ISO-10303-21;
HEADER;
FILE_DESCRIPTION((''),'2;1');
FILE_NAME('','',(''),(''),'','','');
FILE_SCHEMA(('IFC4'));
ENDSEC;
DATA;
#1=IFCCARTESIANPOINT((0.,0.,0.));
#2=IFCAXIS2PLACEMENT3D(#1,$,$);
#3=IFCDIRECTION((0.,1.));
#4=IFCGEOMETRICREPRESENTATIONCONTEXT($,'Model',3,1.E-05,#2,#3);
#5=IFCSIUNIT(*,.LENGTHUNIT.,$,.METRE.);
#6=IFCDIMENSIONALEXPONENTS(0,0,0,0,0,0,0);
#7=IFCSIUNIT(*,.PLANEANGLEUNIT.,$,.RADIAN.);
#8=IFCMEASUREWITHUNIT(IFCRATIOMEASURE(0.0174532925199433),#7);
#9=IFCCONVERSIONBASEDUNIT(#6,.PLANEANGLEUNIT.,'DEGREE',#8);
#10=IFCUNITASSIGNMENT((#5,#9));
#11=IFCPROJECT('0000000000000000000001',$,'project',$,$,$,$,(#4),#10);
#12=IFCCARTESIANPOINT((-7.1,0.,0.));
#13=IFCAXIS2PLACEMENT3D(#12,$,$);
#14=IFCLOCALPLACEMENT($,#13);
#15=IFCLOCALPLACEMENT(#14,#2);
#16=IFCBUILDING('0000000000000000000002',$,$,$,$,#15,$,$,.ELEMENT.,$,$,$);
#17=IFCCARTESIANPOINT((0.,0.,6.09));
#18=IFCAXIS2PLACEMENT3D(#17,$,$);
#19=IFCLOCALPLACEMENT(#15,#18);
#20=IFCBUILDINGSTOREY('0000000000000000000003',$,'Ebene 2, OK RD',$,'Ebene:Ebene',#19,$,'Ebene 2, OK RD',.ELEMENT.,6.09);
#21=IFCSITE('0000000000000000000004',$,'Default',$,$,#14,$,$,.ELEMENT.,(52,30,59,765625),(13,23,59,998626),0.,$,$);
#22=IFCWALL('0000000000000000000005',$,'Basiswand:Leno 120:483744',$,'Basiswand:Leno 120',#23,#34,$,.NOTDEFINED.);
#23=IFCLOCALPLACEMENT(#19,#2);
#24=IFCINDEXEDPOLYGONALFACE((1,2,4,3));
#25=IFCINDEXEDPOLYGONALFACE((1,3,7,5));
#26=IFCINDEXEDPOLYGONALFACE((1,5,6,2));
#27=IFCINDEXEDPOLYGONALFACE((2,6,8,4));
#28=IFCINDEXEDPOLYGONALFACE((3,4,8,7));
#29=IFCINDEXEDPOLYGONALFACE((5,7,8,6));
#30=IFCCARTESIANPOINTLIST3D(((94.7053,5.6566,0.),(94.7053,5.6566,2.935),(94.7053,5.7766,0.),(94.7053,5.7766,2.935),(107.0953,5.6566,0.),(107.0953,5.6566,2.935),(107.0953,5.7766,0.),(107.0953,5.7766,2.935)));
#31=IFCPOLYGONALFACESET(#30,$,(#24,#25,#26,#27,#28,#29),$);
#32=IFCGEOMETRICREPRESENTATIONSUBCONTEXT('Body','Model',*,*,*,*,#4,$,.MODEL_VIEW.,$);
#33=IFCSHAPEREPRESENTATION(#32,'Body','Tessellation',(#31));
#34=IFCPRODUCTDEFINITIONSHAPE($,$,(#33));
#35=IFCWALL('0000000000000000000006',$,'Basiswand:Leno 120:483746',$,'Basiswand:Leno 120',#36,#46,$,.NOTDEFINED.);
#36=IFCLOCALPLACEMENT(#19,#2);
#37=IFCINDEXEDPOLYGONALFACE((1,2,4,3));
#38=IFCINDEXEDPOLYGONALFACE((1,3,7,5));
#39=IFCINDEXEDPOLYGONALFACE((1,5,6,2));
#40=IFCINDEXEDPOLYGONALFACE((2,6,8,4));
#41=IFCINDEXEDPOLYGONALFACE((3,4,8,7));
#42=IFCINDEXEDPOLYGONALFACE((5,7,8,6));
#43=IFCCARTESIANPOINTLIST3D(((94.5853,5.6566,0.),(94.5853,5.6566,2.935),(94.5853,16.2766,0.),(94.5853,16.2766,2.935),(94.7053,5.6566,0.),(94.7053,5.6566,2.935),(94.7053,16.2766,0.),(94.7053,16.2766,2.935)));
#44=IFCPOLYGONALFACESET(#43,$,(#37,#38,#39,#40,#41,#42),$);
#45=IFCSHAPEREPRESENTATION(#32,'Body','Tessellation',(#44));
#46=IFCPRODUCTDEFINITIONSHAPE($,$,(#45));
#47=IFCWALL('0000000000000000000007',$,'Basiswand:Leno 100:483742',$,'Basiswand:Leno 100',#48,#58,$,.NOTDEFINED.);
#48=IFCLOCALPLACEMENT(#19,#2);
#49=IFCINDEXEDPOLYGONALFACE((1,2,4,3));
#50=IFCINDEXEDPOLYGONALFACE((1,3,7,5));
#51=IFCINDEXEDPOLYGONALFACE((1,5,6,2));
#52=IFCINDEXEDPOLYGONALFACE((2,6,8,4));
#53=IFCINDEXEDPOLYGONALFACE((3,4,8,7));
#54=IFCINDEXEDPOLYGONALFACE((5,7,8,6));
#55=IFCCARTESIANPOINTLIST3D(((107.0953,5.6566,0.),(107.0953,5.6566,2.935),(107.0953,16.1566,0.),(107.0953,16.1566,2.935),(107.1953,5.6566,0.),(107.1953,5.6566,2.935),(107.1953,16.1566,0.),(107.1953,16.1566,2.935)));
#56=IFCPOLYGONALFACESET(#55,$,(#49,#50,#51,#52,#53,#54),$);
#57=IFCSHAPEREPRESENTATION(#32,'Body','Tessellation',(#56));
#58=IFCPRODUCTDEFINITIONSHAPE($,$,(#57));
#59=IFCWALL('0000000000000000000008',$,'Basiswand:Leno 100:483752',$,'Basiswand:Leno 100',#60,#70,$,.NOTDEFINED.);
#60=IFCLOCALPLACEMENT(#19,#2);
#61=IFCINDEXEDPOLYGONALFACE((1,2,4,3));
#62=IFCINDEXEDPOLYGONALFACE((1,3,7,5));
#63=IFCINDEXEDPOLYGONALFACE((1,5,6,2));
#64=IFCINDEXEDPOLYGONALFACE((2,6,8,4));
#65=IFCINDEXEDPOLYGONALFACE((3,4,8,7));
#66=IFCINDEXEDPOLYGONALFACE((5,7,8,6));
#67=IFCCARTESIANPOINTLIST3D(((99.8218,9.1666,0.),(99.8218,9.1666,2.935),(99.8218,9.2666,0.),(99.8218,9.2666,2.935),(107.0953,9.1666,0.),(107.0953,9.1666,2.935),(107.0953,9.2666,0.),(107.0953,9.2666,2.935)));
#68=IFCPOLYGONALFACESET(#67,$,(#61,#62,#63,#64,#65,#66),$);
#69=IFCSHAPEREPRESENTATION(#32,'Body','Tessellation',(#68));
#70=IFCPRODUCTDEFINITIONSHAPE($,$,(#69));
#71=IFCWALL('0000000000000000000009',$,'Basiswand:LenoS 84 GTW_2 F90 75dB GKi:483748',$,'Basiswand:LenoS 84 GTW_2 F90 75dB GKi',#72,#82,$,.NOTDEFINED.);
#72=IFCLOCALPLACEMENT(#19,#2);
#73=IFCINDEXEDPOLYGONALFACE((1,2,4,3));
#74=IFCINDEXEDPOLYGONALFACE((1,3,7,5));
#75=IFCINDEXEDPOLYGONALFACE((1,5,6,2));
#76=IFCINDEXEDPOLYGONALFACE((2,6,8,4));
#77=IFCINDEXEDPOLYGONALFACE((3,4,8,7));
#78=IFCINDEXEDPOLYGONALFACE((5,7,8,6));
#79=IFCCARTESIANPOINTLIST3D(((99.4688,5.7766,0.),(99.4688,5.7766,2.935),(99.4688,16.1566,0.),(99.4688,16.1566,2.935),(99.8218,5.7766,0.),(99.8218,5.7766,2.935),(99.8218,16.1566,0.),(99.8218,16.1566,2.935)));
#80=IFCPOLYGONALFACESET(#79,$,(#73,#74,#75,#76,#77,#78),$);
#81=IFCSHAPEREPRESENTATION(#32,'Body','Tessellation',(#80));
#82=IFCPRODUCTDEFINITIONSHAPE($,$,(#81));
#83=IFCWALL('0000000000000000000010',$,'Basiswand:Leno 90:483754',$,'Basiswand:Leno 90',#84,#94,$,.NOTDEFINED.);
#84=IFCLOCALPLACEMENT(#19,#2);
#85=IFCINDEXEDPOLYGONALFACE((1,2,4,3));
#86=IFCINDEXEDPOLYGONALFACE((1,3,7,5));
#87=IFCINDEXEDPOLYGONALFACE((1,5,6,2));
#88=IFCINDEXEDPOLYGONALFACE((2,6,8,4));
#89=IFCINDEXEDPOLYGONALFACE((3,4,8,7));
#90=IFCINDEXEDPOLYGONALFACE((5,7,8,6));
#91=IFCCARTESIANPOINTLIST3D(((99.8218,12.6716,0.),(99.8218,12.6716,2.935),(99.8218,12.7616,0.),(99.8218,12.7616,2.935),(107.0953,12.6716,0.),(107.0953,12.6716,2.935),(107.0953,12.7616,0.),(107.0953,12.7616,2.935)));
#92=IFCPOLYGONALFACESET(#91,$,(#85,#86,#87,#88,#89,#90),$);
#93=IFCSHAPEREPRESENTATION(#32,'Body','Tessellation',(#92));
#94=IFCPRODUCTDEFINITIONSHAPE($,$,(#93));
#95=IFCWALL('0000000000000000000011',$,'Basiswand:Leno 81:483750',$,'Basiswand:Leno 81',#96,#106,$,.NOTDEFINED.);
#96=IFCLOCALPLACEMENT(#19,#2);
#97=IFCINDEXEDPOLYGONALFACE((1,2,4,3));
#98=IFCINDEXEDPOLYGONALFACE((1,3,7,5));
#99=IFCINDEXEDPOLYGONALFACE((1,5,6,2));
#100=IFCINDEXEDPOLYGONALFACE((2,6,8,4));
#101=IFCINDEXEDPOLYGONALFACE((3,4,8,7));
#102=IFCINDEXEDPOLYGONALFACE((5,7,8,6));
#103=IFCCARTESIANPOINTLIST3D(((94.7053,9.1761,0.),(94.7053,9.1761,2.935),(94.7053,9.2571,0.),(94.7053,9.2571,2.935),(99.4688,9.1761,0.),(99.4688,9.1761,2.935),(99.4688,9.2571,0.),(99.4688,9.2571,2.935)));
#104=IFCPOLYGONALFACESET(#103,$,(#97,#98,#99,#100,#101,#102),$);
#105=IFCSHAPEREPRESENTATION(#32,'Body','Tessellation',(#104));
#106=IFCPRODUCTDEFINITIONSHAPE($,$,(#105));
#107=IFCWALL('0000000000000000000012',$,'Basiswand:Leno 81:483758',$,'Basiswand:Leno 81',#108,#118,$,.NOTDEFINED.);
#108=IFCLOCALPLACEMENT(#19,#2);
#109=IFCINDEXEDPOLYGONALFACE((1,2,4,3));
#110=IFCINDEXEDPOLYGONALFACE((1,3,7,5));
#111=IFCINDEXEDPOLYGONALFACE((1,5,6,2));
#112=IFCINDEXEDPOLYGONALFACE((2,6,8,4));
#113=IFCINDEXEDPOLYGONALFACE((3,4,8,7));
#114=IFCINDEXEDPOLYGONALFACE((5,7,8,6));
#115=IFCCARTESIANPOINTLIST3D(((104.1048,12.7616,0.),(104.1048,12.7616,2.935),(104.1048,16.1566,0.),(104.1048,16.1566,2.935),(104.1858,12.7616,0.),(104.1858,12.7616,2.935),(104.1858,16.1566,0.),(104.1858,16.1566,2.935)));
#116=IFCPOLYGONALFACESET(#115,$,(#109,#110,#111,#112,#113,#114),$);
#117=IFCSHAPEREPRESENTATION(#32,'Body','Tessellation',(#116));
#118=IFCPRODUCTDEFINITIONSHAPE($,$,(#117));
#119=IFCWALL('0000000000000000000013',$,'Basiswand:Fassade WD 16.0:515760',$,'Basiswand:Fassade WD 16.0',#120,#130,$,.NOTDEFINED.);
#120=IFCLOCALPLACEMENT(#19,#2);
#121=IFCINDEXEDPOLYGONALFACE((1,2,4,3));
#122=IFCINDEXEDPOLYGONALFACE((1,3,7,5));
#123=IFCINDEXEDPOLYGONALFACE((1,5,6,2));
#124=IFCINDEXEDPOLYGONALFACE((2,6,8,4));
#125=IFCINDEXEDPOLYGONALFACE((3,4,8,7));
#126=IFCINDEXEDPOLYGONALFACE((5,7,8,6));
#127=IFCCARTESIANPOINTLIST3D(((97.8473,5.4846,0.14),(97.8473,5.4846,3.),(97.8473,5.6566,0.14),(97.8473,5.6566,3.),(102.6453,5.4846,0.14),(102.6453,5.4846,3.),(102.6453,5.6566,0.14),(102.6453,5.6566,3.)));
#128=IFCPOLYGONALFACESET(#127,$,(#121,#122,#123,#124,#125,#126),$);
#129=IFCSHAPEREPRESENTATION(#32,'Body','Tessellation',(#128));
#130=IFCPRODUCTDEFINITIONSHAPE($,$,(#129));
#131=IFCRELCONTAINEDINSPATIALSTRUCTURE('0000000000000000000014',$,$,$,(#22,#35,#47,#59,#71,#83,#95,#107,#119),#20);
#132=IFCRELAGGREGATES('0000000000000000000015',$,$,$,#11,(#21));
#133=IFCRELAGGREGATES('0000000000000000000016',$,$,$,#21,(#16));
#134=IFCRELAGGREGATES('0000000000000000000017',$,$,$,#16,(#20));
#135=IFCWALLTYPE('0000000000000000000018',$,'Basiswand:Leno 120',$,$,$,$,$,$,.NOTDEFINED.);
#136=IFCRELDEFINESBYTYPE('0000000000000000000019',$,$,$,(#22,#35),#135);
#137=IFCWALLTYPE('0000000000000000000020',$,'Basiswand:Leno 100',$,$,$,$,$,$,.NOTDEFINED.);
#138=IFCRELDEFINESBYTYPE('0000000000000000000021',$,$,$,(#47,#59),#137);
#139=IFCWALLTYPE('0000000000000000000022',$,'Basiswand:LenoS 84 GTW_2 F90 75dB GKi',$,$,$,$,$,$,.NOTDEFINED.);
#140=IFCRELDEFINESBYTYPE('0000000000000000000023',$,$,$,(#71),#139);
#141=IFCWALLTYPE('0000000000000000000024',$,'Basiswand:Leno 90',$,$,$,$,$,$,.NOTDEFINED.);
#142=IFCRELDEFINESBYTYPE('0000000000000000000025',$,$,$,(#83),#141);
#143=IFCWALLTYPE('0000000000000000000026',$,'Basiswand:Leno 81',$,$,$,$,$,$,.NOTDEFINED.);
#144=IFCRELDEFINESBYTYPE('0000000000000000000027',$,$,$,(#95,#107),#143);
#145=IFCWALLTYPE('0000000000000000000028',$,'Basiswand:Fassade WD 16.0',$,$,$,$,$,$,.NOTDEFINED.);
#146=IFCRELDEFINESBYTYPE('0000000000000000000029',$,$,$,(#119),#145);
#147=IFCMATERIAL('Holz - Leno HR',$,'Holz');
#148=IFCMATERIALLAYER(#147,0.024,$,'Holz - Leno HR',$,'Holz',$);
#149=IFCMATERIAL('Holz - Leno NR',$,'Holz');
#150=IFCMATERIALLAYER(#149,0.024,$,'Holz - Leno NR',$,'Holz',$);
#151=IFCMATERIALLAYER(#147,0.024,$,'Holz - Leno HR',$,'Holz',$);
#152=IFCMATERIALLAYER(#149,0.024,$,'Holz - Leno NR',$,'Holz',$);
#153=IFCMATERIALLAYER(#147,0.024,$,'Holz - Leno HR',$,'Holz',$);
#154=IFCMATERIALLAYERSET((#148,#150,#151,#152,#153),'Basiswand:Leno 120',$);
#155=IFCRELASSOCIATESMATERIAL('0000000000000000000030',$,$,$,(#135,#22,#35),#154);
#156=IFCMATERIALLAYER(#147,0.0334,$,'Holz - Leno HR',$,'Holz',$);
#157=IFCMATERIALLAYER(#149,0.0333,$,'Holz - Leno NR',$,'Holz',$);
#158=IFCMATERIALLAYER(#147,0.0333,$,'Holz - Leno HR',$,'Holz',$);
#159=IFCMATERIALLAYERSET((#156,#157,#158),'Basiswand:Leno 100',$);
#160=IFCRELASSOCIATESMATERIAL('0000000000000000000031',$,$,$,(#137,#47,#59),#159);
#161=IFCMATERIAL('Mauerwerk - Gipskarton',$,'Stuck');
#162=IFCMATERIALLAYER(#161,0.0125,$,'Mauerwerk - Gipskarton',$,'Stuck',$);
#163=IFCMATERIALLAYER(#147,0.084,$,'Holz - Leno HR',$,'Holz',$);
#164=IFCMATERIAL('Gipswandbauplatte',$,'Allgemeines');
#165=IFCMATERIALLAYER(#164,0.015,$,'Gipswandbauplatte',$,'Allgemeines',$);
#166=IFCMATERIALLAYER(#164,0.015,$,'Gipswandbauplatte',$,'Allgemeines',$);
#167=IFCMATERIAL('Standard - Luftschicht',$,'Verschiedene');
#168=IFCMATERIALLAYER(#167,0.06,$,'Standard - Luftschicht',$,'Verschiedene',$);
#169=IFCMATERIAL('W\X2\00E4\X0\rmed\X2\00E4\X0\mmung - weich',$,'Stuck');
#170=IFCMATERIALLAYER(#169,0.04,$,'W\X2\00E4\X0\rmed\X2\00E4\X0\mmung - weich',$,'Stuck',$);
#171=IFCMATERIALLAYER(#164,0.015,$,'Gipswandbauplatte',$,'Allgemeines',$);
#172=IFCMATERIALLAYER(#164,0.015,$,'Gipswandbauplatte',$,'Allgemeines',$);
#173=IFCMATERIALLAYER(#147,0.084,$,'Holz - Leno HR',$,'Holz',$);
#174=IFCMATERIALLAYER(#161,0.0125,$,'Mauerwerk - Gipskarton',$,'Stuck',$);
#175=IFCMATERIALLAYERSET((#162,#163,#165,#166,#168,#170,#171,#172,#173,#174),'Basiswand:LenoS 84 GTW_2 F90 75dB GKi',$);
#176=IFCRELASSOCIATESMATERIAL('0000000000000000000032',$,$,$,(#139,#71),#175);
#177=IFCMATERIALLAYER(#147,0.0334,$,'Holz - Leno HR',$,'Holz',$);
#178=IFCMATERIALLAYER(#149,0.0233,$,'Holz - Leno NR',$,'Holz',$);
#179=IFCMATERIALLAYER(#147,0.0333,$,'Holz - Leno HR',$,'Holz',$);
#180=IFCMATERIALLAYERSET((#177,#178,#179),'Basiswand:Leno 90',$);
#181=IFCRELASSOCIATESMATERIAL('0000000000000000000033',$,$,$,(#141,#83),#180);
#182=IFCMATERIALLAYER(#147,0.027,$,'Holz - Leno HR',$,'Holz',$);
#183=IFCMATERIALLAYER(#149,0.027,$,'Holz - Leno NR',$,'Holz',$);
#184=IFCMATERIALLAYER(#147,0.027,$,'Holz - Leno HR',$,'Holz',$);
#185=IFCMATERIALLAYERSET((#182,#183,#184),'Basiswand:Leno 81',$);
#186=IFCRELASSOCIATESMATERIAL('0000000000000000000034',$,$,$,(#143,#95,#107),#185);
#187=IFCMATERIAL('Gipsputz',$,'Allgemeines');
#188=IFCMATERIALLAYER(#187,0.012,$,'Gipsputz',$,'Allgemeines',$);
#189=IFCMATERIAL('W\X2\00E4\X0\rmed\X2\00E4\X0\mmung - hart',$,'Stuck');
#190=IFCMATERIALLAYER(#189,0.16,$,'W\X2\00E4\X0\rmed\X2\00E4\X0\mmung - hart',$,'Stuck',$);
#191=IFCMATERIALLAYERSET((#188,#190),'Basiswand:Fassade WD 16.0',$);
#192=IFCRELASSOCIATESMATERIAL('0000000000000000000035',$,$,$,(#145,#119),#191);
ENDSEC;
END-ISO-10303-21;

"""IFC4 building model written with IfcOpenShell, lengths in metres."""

from ifc_helpers import new_model, entity, si_unit, converted_unit, direction, frame, frame_2d, origin, place, context, subcontext, project, spatial, rectangle, extrude, material, layer, layer_set, layer_usage, type_object, element, save


model = new_model("IFC4")

# Units and contexts
model_context = context("Model", 3, precision=1e-05, world=origin(), true_north=direction((0.0, 1.0)))
body_context = subcontext(model_context, "Body", "Model", "MODEL_VIEW")
ifc_project = project(units=[si_unit("LENGTHUNIT", "METRE"), converted_unit("PLANEANGLEUNIT", "DEGREE", entity("IfcRatioMeasure", 0.0174532925199433), si_unit("PLANEANGLEUNIT", "RADIAN"), dimensions=[0, 0, 0, 0, 0, 0, 0])], contexts=[model_context])

# Site, building, storey
site_placement = place(None, frame((-7.1, 0.0, 0.0)))
site = spatial("IfcSite", under=ifc_project, at=site_placement, Name="Default", CompositionType="ELEMENT", RefLatitude=(52, 30, 59, 765625), RefLongitude=(13, 23, 59, 998626), RefElevation=0.0)
building_placement = place(site_placement, origin())
building = spatial("IfcBuilding", under=site, at=building_placement, CompositionType="ELEMENT")
storey_placement = place(building_placement, frame((0.0, 0.0, 6.09)))
storey = spatial("IfcBuildingStorey", under=building, at=storey_placement, Name="Ebene 2, OK RD", ObjectType="Ebene:Ebene", LongName="Ebene 2, OK RD", CompositionType="ELEMENT", Elevation=6.09)

# Shared definitions
ifc_material_1 = material(Name="Holz - Leno HR", Category="Holz")
ifc_material_2 = material(Name="Holz - Leno NR", Category="Holz")
ifc_material_3 = material(Name="Wärmedämmung - hart", Category="Stuck")

# Walls
ifc_layer_1 = layer(ifc_material_1, 0.024, Name="Holz - Leno HR", Category="Holz")
ifc_layer_2 = layer(ifc_material_2, 0.024, Name="Holz - Leno NR", Category="Holz")
ifc_layer_3 = layer(ifc_material_1, 0.024, Name="Holz - Leno HR", Category="Holz")
ifc_layer_4 = layer(ifc_material_2, 0.024, Name="Holz - Leno NR", Category="Holz")
ifc_layer_5 = layer(ifc_material_1, 0.024, Name="Holz - Leno HR", Category="Holz")
ifc_layer_set_1 = layer_set([ifc_layer_1, ifc_layer_2, ifc_layer_3, ifc_layer_4, ifc_layer_5], Name="Basiswand:Leno 120")
wall_type_1 = type_object("IfcWallType", Name="Basiswand:Leno 120", PredefinedType="NOTDEFINED", material=ifc_layer_set_1)
ifc_layer_usage_1 = layer_usage(ifc_layer_set_1, "AXIS2", "NEGATIVE", 0.06)
wall_1_placement = place(storey_placement, frame((107.0953, 5.7166, 0.0), z_axis=(0.0, 0.0, 1.0), x_axis=(-1.0, 0.0, 0.0)))
element("IfcWall", 1, at=wall_1_placement, inside=storey, type_object=wall_type_1, material=ifc_layer_usage_1, Name="Basiswand:Leno 120:483744", ObjectType="Basiswand:Leno 120", PredefinedType="NOTDEFINED", context=body_context, shape_type="SweptSolid", body=[
    extrude(rectangle(XDim=12.39, YDim=0.12, at=frame_2d((6.195, 0.0), x_axis=(-1.0, 0.0))), origin(), (0.0, 0.0, 1.0), 2.935),
])
ifc_layer_usage_2 = layer_usage(ifc_layer_set_1, "AXIS2", "NEGATIVE", 0.06)
wall_2_placement = place(storey_placement, frame((94.6453, 5.6566, 0.0), z_axis=(0.0, 0.0, 1.0), x_axis=(0.0, 1.0, 0.0)))
element("IfcWall", 2, at=wall_2_placement, inside=storey, type_object=wall_type_1, material=ifc_layer_usage_2, Name="Basiswand:Leno 120:483746", ObjectType="Basiswand:Leno 120", PredefinedType="NOTDEFINED", context=body_context, shape_type="SweptSolid", body=[
    extrude(rectangle(XDim=10.62, YDim=0.12, at=frame_2d((5.31, 0.0), x_axis=(-1.0, 0.0))), origin(), (0.0, 0.0, 1.0), 2.935),
])
ifc_layer_6 = layer(ifc_material_1, 0.0334, Name="Holz - Leno HR", Category="Holz")
ifc_layer_7 = layer(ifc_material_2, 0.0333, Name="Holz - Leno NR", Category="Holz")
ifc_layer_8 = layer(ifc_material_1, 0.0333, Name="Holz - Leno HR", Category="Holz")
ifc_layer_set_2 = layer_set([ifc_layer_6, ifc_layer_7, ifc_layer_8], Name="Basiswand:Leno 100")
ifc_layer_usage_3 = layer_usage(ifc_layer_set_2, "AXIS2", "NEGATIVE", 0.05)
wall_type_2 = type_object("IfcWallType", Name="Basiswand:Leno 100", PredefinedType="NOTDEFINED", material=ifc_layer_set_2)
wall_3_placement = place(storey_placement, frame((107.1453, 16.1566, 0.0), z_axis=(0.0, 0.0, 1.0), x_axis=(0.0, -1.0, 0.0)))
element("IfcWall", 3, at=wall_3_placement, inside=storey, type_object=wall_type_2, material=ifc_layer_usage_3, Name="Basiswand:Leno 100:483742", ObjectType="Basiswand:Leno 100", PredefinedType="NOTDEFINED", context=body_context, shape_type="SweptSolid", body=[
    extrude(rectangle(XDim=10.5, YDim=0.1, at=frame_2d((5.25, 0.0), x_axis=(-1.0, 0.0))), origin(), (0.0, 0.0, 1.0), 2.935),
])
ifc_layer_usage_4 = layer_usage(ifc_layer_set_2, "AXIS2", "NEGATIVE", 0.05)
wall_4_placement = place(storey_placement, frame((107.0953, 9.2166, 0.0), z_axis=(0.0, 0.0, 1.0), x_axis=(-1.0, 0.0, 0.0)))
element("IfcWall", 4, at=wall_4_placement, inside=storey, type_object=wall_type_2, material=ifc_layer_usage_4, Name="Basiswand:Leno 100:483752", ObjectType="Basiswand:Leno 100", PredefinedType="NOTDEFINED", context=body_context, shape_type="SweptSolid", body=[
    extrude(rectangle(XDim=7.2735, YDim=0.1, at=frame_2d((3.6367, 0.0), x_axis=(-1.0, 0.0))), origin(), (0.0, 0.0, 1.0), 2.935),
])
ifc_material_4 = material(Name="Mauerwerk - Gipskarton", Category="Stuck")
ifc_layer_9 = layer(ifc_material_4, 0.0125, Name="Mauerwerk - Gipskarton", Category="Stuck")
ifc_layer_10 = layer(ifc_material_1, 0.084, Name="Holz - Leno HR", Category="Holz")
ifc_material_5 = material(Name="Gipswandbauplatte", Category="Allgemeines")
ifc_layer_11 = layer(ifc_material_5, 0.015, Name="Gipswandbauplatte", Category="Allgemeines")
ifc_layer_12 = layer(ifc_material_5, 0.015, Name="Gipswandbauplatte", Category="Allgemeines")
ifc_material_6 = material(Name="Standard - Luftschicht", Category="Verschiedene")
ifc_layer_13 = layer(ifc_material_6, 0.06, Name="Standard - Luftschicht", Category="Verschiedene")
ifc_material_7 = material(Name="Wärmedämmung - weich", Category="Stuck")
ifc_layer_14 = layer(ifc_material_7, 0.04, Name="Wärmedämmung - weich", Category="Stuck")
ifc_layer_15 = layer(ifc_material_5, 0.015, Name="Gipswandbauplatte", Category="Allgemeines")
ifc_layer_16 = layer(ifc_material_5, 0.015, Name="Gipswandbauplatte", Category="Allgemeines")
ifc_layer_17 = layer(ifc_material_1, 0.084, Name="Holz - Leno HR", Category="Holz")
ifc_layer_18 = layer(ifc_material_4, 0.0125, Name="Mauerwerk - Gipskarton", Category="Stuck")
ifc_layer_set_3 = layer_set([ifc_layer_9, ifc_layer_10, ifc_layer_11, ifc_layer_12, ifc_layer_13, ifc_layer_14, ifc_layer_15, ifc_layer_16, ifc_layer_17, ifc_layer_18], Name="Basiswand:LenoS 84 GTW_2 F90 75dB GKi")
ifc_layer_usage_5 = layer_usage(ifc_layer_set_3, "AXIS2", "NEGATIVE", 0.1765)
wall_type_3 = type_object("IfcWallType", Name="Basiswand:LenoS 84 GTW_2 F90 75dB GKi", PredefinedType="NOTDEFINED", material=ifc_layer_set_3)
wall_5_placement = place(storey_placement, frame((99.6453, 16.1566, 0.0), z_axis=(0.0, 0.0, 1.0), x_axis=(0.0, -1.0, 0.0)))
element("IfcWall", 5, at=wall_5_placement, inside=storey, type_object=wall_type_3, material=ifc_layer_usage_5, Name="Basiswand:LenoS 84 GTW_2 F90 75dB GKi:483748", ObjectType="Basiswand:LenoS 84 GTW_2 F90 75dB GKi", PredefinedType="NOTDEFINED", context=body_context, shape_type="SweptSolid", body=[
    extrude(rectangle(XDim=10.38, YDim=0.353, at=frame_2d((5.19, 0.0), x_axis=(-1.0, 0.0))), origin(), (0.0, 0.0, 1.0), 2.935),
])
ifc_layer_19 = layer(ifc_material_1, 0.0334, Name="Holz - Leno HR", Category="Holz")
ifc_layer_20 = layer(ifc_material_2, 0.0233, Name="Holz - Leno NR", Category="Holz")
ifc_layer_21 = layer(ifc_material_1, 0.0333, Name="Holz - Leno HR", Category="Holz")
ifc_layer_set_4 = layer_set([ifc_layer_19, ifc_layer_20, ifc_layer_21], Name="Basiswand:Leno 90")
ifc_layer_usage_6 = layer_usage(ifc_layer_set_4, "AXIS2", "NEGATIVE", 0.045)
wall_type_4 = type_object("IfcWallType", Name="Basiswand:Leno 90", PredefinedType="NOTDEFINED", material=ifc_layer_set_4)
wall_6_placement = place(storey_placement, frame((107.0953, 12.7166, 0.0), z_axis=(0.0, 0.0, 1.0), x_axis=(-1.0, 0.0, 0.0)))
element("IfcWall", 6, at=wall_6_placement, inside=storey, type_object=wall_type_4, material=ifc_layer_usage_6, Name="Basiswand:Leno 90:483754", ObjectType="Basiswand:Leno 90", PredefinedType="NOTDEFINED", context=body_context, shape_type="SweptSolid", body=[
    extrude(rectangle(XDim=7.2735, YDim=0.09, at=frame_2d((3.6367, 0.0), x_axis=(-1.0, 0.0))), origin(), (0.0, 0.0, 1.0), 2.935),
])
ifc_layer_22 = layer(ifc_material_1, 0.027, Name="Holz - Leno HR", Category="Holz")
ifc_layer_23 = layer(ifc_material_2, 0.027, Name="Holz - Leno NR", Category="Holz")
ifc_layer_24 = layer(ifc_material_1, 0.027, Name="Holz - Leno HR", Category="Holz")
ifc_layer_set_5 = layer_set([ifc_layer_22, ifc_layer_23, ifc_layer_24], Name="Basiswand:Leno 81")
ifc_layer_usage_7 = layer_usage(ifc_layer_set_5, "AXIS2", "NEGATIVE", 0.0405)
wall_type_5 = type_object("IfcWallType", Name="Basiswand:Leno 81", PredefinedType="NOTDEFINED", material=ifc_layer_set_5)
wall_7_placement = place(storey_placement, frame((94.7053, 9.2166, 0.0)))
element("IfcWall", 7, at=wall_7_placement, inside=storey, type_object=wall_type_5, material=ifc_layer_usage_7, Name="Basiswand:Leno 81:483750", ObjectType="Basiswand:Leno 81", PredefinedType="NOTDEFINED", context=body_context, shape_type="SweptSolid", body=[
    extrude(rectangle(XDim=4.7635, YDim=0.081, at=frame_2d((2.3817, 0.0), x_axis=(-1.0, 0.0))), origin(), (0.0, 0.0, 1.0), 2.935),
])
ifc_layer_usage_8 = layer_usage(ifc_layer_set_5, "AXIS2", "NEGATIVE", 0.0405)
wall_8_placement = place(storey_placement, frame((104.1453, 12.7616, 0.0), z_axis=(0.0, 0.0, 1.0), x_axis=(0.0, 1.0, 0.0)))
element("IfcWall", 8, at=wall_8_placement, inside=storey, type_object=wall_type_5, material=ifc_layer_usage_8, Name="Basiswand:Leno 81:483758", ObjectType="Basiswand:Leno 81", PredefinedType="NOTDEFINED", context=body_context, shape_type="SweptSolid", body=[
    extrude(rectangle(XDim=3.395, YDim=0.081, at=frame_2d((1.6975, 0.0), x_axis=(-1.0, 0.0))), origin(), (0.0, 0.0, 1.0), 2.935),
])
ifc_material_8 = material(Name="Gipsputz", Category="Allgemeines")
ifc_layer_25 = layer(ifc_material_8, 0.012, Name="Gipsputz", Category="Allgemeines")
ifc_layer_26 = layer(ifc_material_3, 0.16, Name="Wärmedämmung - hart", Category="Stuck")
ifc_layer_set_6 = layer_set([ifc_layer_25, ifc_layer_26], Name="Basiswand:Fassade WD 16.0")
ifc_layer_usage_9 = layer_usage(ifc_layer_set_6, "AXIS2", "NEGATIVE", 0.086)
wall_type_6 = type_object("IfcWallType", Name="Basiswand:Fassade WD 16.0", PredefinedType="NOTDEFINED", material=ifc_layer_set_6)
wall_9_placement = place(storey_placement, frame((102.6453, 5.5706, 0.14), z_axis=(0.0, 0.0, 1.0), x_axis=(-1.0, 0.0, 0.0)))
element("IfcWall", 9, at=wall_9_placement, inside=storey, type_object=wall_type_6, material=ifc_layer_usage_9, Name="Basiswand:Fassade WD 16.0:515760", ObjectType="Basiswand:Fassade WD 16.0", PredefinedType="NOTDEFINED", context=body_context, shape_type="SweptSolid", body=[
    extrude(rectangle(XDim=4.798, YDim=0.172, at=frame_2d((2.399, 0.0), x_axis=(-1.0, 0.0))), origin(), (0.0, 0.0, 1.0), 2.86),
])

save(model, "model.ifc")
